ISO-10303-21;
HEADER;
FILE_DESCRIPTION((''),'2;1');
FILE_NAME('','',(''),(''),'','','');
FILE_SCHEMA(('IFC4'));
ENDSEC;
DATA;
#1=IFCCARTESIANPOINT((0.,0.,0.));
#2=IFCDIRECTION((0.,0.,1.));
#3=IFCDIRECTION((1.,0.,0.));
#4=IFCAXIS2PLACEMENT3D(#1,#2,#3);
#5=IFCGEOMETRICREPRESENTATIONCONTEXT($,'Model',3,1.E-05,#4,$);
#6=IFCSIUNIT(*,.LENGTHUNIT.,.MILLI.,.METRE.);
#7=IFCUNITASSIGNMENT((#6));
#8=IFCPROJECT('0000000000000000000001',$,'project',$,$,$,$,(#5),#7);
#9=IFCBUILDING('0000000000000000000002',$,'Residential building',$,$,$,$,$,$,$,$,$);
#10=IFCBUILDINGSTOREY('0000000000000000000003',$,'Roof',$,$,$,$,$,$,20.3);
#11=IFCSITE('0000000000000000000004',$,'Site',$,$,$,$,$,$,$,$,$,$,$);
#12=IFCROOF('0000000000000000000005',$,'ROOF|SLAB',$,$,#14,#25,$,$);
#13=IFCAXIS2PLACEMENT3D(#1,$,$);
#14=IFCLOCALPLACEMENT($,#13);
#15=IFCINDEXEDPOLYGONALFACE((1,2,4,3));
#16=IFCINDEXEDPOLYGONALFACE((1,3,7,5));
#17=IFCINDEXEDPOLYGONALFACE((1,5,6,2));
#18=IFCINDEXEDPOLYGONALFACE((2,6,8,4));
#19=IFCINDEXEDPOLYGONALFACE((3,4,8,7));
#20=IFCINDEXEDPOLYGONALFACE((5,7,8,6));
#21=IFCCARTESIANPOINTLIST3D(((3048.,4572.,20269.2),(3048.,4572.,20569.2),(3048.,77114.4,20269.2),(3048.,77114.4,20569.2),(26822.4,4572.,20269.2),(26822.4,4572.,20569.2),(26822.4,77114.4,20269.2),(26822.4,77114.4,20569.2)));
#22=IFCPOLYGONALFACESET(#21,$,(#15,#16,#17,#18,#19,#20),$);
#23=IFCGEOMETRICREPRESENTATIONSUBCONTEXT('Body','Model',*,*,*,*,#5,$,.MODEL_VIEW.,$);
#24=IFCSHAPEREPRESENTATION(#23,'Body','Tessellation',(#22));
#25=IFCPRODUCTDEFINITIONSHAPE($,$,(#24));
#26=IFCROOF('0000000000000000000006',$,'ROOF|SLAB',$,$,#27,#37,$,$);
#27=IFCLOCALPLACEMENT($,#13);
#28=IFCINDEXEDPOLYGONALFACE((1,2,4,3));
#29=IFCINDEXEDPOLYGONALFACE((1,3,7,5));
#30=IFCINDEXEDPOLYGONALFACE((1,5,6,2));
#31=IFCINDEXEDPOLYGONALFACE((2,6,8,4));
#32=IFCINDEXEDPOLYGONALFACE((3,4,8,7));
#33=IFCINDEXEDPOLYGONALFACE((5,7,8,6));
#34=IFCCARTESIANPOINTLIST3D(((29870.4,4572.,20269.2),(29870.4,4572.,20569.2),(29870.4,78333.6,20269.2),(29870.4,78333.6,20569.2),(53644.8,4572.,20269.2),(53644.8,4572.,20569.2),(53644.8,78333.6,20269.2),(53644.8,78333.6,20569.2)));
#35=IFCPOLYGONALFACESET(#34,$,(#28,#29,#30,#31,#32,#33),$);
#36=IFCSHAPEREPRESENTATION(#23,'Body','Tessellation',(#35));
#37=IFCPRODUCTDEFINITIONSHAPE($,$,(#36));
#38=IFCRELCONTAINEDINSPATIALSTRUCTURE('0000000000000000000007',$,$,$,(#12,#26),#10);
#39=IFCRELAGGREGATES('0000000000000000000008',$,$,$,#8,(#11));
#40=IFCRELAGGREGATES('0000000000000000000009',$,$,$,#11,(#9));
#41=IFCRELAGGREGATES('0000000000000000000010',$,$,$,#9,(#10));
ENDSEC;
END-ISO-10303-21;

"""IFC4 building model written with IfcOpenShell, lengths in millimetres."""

from ifc_helpers import new_model, si_unit, frame, origin_with_axes, place, context, subcontext, project, spatial, indexed_curve, outline, extrude, element, save


model = new_model("IFC4")

# Units and contexts
model_context = context("Model", 3, precision=1e-05, world=origin_with_axes())
body_context = subcontext(model_context, "Body", "Model", "MODEL_VIEW")
ifc_project = project(units=[si_unit("LENGTHUNIT", "METRE", prefix="MILLI")], contexts=[model_context])

# Site, building, storey
site = spatial("IfcSite", under=ifc_project, Name="Site")
building = spatial("IfcBuilding", under=site, Name="Residential building")
storey = spatial("IfcBuildingStorey", under=building, Name="Roof", Elevation=20.3)

# Roofs
roof_1_placement = place(None, frame((3048.0, 4572.0, 20269.2), z_axis=(0.0, 0.0, 1.0), x_axis=(1.0, 0.0, 0.0)))
element("IfcRoof", 1, at=roof_1_placement, inside=storey, Name="ROOF|SLAB", context=body_context, shape_type="SweptSolid", body=[
    extrude(outline(indexed_curve([(0.0, 0.0), (23774.4, 0.0), (23774.4, 72542.4), (0.0, 72542.4), (0.0, 0.0)])), None, (0.0, 0.0, 1.0), 300.0),
])
roof_2_placement = place(None, frame((29870.4, 4572.0, 20269.2), z_axis=(0.0, 0.0, 1.0), x_axis=(1.0, 0.0, 0.0)))
element("IfcRoof", 2, at=roof_2_placement, inside=storey, Name="ROOF|SLAB", context=body_context, shape_type="SweptSolid", body=[
    extrude(outline(indexed_curve([(0.0, 0.0), (23774.4, 0.0), (23774.4, 73761.6), (0.0, 73761.6), (0.0, 0.0)])), None, (0.0, 0.0, 1.0), 300.0),
])

save(model, "model.ifc")
